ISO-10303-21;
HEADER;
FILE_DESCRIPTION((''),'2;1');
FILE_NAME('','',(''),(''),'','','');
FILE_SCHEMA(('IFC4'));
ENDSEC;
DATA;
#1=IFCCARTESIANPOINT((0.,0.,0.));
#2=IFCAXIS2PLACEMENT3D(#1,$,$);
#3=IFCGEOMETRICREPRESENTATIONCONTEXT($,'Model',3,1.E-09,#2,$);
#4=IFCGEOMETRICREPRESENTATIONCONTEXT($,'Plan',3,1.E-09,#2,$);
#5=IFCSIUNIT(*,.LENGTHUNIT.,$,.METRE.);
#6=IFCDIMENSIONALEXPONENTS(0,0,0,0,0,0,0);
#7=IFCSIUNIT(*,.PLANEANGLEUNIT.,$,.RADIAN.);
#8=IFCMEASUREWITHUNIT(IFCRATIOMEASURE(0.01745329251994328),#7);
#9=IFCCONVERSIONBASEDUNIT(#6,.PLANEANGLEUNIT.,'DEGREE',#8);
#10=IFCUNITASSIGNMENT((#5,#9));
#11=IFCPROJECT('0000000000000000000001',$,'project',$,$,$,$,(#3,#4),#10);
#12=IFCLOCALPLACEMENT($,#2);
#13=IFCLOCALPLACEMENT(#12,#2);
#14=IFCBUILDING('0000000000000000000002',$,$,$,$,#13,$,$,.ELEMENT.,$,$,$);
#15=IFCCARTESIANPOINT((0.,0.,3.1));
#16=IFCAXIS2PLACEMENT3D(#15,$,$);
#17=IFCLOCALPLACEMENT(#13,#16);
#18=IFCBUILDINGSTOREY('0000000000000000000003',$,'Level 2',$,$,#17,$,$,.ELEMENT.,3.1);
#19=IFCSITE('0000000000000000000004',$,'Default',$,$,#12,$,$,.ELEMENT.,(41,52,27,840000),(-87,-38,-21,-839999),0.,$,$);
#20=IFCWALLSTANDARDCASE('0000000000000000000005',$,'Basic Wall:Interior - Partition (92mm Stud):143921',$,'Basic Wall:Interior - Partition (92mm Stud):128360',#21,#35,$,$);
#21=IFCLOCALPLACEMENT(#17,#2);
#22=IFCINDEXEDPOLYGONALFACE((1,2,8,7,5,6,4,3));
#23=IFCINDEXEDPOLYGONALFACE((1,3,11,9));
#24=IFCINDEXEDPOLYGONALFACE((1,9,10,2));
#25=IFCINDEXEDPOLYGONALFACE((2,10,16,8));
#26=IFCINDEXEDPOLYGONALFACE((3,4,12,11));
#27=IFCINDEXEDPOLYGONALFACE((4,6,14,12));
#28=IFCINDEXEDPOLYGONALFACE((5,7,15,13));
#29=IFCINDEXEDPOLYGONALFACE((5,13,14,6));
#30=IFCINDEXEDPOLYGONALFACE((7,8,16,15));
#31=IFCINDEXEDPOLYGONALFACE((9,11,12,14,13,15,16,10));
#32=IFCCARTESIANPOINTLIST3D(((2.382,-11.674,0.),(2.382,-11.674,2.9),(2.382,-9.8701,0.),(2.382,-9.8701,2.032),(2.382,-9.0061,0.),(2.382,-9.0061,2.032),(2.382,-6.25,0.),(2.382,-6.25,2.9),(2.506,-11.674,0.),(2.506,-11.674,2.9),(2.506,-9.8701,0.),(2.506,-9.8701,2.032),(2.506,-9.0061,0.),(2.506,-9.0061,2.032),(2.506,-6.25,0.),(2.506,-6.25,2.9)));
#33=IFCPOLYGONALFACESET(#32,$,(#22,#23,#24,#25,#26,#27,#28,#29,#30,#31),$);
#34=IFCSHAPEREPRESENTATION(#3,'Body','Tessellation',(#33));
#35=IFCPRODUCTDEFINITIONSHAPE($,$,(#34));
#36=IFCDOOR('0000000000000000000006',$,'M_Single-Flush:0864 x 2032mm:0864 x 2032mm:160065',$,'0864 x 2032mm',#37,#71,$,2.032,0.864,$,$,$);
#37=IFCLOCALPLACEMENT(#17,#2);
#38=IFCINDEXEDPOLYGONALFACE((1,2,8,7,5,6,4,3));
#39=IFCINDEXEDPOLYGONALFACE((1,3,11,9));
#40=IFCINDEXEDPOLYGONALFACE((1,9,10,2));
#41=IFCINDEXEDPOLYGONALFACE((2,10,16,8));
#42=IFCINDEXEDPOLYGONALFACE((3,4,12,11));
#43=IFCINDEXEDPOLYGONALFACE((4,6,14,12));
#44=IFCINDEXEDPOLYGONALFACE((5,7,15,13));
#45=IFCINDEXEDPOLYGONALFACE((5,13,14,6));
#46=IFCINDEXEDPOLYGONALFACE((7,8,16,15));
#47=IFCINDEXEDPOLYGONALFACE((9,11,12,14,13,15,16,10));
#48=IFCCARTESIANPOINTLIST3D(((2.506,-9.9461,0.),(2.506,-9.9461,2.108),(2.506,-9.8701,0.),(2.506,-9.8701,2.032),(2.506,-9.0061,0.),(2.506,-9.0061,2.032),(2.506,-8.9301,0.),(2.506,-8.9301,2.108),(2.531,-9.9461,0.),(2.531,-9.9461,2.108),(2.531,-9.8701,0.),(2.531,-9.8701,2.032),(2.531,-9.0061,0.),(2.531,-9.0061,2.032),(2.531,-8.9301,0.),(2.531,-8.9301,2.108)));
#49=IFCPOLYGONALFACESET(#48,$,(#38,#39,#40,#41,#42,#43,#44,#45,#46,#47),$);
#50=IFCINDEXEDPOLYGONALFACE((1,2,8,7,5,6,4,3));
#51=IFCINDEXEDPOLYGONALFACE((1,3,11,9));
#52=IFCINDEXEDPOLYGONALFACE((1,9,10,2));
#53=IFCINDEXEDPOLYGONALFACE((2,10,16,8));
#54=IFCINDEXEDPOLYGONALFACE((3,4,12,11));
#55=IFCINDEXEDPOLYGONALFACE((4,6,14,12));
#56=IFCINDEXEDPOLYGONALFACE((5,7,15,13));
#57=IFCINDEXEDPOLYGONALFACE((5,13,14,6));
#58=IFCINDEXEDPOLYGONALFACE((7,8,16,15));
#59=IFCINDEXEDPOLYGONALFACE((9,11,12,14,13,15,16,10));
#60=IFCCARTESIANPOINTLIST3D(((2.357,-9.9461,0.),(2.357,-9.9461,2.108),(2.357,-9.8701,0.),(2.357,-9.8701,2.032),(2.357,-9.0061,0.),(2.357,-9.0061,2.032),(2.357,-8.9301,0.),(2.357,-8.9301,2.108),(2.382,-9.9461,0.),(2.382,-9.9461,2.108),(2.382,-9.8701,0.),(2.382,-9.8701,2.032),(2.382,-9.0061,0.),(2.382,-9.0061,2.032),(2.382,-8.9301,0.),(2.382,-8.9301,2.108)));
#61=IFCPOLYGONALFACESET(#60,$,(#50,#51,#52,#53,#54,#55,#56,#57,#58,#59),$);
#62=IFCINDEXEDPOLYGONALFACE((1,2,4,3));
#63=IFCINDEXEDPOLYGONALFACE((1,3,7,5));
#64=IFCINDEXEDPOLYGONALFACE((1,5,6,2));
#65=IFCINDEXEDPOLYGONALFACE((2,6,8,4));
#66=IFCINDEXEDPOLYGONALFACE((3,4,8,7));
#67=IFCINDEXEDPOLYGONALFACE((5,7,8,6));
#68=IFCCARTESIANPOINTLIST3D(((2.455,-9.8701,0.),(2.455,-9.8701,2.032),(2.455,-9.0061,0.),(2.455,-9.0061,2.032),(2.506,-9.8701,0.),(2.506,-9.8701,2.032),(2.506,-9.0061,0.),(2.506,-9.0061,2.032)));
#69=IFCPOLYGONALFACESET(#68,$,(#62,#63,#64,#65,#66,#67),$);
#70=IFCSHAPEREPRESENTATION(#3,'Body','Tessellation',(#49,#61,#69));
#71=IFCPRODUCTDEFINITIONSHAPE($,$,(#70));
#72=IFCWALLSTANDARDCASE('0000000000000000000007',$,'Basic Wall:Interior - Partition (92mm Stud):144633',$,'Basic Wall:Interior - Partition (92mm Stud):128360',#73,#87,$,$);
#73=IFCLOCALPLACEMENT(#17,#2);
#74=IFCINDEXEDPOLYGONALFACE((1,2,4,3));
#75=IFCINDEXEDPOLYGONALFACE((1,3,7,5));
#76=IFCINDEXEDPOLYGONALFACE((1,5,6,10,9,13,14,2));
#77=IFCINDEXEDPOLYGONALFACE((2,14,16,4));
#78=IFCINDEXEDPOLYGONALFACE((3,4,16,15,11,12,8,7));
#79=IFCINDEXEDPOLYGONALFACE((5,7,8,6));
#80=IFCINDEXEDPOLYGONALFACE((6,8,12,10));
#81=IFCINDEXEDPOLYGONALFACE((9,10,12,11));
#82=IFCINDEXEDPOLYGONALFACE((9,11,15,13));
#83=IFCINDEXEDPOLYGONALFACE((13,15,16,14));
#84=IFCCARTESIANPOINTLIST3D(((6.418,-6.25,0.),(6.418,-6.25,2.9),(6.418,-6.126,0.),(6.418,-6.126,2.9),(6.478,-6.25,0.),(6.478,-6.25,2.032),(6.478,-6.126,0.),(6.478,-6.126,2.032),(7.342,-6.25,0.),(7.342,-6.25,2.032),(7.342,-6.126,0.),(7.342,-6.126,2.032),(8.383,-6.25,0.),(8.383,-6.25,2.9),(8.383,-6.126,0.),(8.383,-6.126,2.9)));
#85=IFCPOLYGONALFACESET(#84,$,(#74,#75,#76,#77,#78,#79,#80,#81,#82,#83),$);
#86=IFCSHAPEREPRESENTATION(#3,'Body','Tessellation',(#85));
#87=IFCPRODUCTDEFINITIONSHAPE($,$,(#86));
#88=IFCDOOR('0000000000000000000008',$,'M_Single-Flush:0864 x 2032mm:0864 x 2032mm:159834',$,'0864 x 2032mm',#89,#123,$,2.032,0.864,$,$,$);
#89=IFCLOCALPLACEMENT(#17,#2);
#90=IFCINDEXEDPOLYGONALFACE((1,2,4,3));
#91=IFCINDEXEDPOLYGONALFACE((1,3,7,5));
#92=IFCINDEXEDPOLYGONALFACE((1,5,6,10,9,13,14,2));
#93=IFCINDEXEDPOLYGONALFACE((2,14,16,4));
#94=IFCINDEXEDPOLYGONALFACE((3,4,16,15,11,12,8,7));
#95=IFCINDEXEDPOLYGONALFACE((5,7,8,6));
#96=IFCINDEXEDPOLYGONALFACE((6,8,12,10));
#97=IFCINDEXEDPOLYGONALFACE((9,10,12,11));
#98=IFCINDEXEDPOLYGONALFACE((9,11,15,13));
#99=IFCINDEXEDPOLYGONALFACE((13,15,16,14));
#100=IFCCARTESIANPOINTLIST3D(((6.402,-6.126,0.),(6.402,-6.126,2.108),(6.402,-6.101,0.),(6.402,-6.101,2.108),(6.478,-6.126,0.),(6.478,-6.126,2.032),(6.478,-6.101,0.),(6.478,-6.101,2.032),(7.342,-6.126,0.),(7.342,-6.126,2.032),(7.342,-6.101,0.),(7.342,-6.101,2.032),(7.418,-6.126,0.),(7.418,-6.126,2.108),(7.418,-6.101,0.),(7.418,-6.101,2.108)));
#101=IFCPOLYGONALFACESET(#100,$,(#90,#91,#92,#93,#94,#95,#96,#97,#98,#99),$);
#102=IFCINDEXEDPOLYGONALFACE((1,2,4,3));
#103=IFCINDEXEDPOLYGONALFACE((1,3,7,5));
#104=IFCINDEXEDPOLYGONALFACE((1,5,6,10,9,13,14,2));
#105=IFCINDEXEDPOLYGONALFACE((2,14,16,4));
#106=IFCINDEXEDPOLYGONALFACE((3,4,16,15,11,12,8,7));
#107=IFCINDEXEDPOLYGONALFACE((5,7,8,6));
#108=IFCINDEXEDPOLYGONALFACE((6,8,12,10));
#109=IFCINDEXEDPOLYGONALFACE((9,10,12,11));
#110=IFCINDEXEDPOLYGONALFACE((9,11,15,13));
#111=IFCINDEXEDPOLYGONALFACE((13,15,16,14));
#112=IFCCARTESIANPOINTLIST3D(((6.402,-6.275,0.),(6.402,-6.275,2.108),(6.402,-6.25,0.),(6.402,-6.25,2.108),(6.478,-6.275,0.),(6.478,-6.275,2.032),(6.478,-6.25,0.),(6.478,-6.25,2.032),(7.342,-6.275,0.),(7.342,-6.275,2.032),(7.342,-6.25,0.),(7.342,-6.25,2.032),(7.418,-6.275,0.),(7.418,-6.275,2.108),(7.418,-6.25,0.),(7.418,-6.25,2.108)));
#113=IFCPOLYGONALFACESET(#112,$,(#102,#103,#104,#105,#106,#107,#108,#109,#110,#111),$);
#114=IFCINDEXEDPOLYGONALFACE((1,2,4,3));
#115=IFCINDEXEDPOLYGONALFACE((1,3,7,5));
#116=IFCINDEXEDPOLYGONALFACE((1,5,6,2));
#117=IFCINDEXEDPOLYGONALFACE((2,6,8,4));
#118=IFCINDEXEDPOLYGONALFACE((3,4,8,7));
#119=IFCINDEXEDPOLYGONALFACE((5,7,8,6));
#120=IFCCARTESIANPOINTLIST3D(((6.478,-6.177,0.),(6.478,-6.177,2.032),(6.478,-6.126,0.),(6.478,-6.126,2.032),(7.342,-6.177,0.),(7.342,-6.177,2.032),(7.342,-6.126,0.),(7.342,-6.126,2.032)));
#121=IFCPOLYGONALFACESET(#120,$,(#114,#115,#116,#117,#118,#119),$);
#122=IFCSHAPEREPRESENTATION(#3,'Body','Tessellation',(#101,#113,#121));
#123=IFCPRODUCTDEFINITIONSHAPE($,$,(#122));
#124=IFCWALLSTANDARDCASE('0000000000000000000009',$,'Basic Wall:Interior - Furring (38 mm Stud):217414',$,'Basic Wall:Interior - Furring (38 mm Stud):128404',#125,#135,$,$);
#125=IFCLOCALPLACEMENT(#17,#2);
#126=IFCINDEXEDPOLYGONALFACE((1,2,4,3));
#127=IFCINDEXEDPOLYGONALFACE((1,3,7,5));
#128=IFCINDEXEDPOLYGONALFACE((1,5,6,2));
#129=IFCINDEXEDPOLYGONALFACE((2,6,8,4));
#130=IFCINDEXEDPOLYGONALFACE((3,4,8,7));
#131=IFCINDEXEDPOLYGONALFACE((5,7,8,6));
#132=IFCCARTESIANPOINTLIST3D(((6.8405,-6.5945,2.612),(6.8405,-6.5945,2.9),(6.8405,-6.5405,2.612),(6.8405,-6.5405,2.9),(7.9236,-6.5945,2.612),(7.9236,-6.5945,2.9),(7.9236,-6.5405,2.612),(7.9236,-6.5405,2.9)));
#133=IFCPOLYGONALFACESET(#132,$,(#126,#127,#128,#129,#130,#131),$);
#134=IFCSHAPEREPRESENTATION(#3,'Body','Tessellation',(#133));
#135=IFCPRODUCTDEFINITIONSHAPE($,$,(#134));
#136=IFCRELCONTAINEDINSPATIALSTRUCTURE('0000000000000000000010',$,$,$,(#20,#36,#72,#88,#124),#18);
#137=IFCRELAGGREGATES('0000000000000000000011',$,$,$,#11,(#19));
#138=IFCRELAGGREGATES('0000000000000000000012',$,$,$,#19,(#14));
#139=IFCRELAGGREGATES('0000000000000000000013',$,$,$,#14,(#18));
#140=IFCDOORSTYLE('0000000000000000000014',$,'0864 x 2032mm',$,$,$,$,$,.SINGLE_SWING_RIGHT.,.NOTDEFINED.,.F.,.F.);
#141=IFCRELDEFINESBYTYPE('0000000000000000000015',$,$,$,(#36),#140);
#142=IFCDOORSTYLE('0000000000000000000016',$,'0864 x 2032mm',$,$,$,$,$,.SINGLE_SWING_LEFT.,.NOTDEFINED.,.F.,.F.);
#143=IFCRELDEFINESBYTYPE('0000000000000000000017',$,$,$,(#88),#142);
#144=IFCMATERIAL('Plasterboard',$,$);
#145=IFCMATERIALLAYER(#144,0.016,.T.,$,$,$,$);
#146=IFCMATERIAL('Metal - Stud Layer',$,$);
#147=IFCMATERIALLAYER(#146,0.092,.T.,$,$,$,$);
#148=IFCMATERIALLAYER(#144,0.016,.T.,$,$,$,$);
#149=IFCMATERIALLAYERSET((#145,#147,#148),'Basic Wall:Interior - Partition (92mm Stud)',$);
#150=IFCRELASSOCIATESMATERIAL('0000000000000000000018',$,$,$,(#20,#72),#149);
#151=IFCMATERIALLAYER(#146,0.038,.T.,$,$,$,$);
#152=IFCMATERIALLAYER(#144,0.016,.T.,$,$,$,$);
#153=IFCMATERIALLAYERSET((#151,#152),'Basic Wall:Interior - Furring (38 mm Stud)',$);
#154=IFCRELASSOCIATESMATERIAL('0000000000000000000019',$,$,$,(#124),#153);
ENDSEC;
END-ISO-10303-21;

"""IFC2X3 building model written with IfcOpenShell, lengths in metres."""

from ifc_helpers import new_model, entity, si_unit, converted_unit, frame, frame_2d, origin, origin_2d_with_axis, place, context, project, spatial, polyline, rectangle, outline, extrude, source, transform, mapped, material, layer, layer_set, layer_usage, type_object, type_shapes, element, fill, save


model = new_model("IFC2X3")

# Units and contexts
model_context = context("Model", 3, precision=1e-09, world=origin())
plan_context = context("Plan", 3, precision=1e-09, world=origin())
ifc_project = project(units=[si_unit("LENGTHUNIT", "METRE"), converted_unit("PLANEANGLEUNIT", "DEGREE", entity("IfcRatioMeasure", 0.01745329251994328), si_unit("PLANEANGLEUNIT", "RADIAN"), dimensions=[0, 0, 0, 0, 0, 0, 0])], contexts=[model_context, plan_context])

# Site, building, storey
site_placement = place(None, origin())
site = spatial("IfcSite", under=ifc_project, at=site_placement, Name="Default", CompositionType="ELEMENT", RefLatitude=(41, 52, 27, 840000), RefLongitude=(-87, -38, -21, -839999), RefElevation=0.0)
building_placement = place(site_placement, origin())
building = spatial("IfcBuilding", under=site, at=building_placement, CompositionType="ELEMENT")
storey_placement = place(building_placement, frame((0.0, 0.0, 3.1)))
storey = spatial("IfcBuildingStorey", under=building, at=storey_placement, Name="Level 2", CompositionType="ELEMENT", Elevation=3.1)

# Shared definitions
ifc_material_1 = material(Name="Metal - Stud Layer")
ifc_layer_1 = layer(ifc_material_1, 0.038, ventilated=True)
ifc_material_2 = material(Name="Plasterboard")
ifc_layer_2 = layer(ifc_material_2, 0.016, ventilated=True)
ifc_layer_set_1 = layer_set([ifc_layer_1, ifc_layer_2], Name="Basic Wall:Interior - Furring (38 mm Stud)")
ifc_layer_usage_1 = layer_usage(ifc_layer_set_1, "AXIS2", "NEGATIVE", 0.027)

# Walls, openings, doors
ifc_layer_3 = layer(ifc_material_2, 0.016, ventilated=True)
ifc_layer_4 = layer(ifc_material_1, 0.092, ventilated=True)
ifc_layer_5 = layer(ifc_material_2, 0.016, ventilated=True)
ifc_layer_set_2 = layer_set([ifc_layer_3, ifc_layer_4, ifc_layer_5], Name="Basic Wall:Interior - Partition (92mm Stud)")
ifc_layer_usage_2 = layer_usage(ifc_layer_set_2, "AXIS2", "NEGATIVE", 0.062)
wall_1_placement = place(storey_placement, frame((2.444, -6.25, 0.0), z_axis=(0.0, 0.0, 1.0), x_axis=(0.0, -1.0, 0.0)))
wall_1 = element("IfcWallStandardCase", 1, at=wall_1_placement, inside=storey, material=ifc_layer_usage_2, Name="Basic Wall:Interior - Partition (92mm Stud):143921", ObjectType="Basic Wall:Interior - Partition (92mm Stud):128360", context=model_context, shape_type="SweptSolid", body=[
    extrude(rectangle(XDim=5.424, YDim=0.124, at=frame_2d((2.712, 0.0), x_axis=(-1.0, 0.0))), origin(), (0.0, 0.0, 1.0), 2.9),
])
opening_1_placement = place(wall_1_placement, frame((2.7561, -0.062, 0.0)))
opening_1 = element("IfcOpeningElement", 2, at=opening_1_placement, cuts=wall_1, ObjectType="Opening", context=model_context, shape_type="SweptSolid", body=[
    extrude(rectangle(XDim=0.864, YDim=2.032, at=frame_2d((1.016, 0.432), x_axis=(0.0, 1.0))), frame((0.0, 0.0, 0.0), z_axis=(0.0, 1.0, 0.0), x_axis=(0.0, 0.0, 1.0)), (0.0, 0.0, 1.0), 0.124),
])
door_style_1 = type_object("IfcDoorStyle", Name="0864 x 2032mm", ConstructionType="NOTDEFINED", OperationType="SINGLE_SWING_RIGHT", ParameterTakesPrecedence=False, Sizeable=False)
shared_shape_1 = source(origin(), model_context, "Body", "SweptSolid", [
    extrude(outline(polyline([(-0.508, -1.073), (0.508, -1.073), (0.508, 1.035), (0.432, 1.035), (0.432, -0.997), (-0.432, -0.997), (-0.432, 1.035), (-0.508, 1.035), (-0.508, -1.073)])), frame((0.432, 0.124, 1.035), z_axis=(0.0, 1.0, 0.0), x_axis=(1.0, 0.0, 0.0)), (0.0, 0.0, 1.0), 0.025),
    extrude(outline(polyline([(-1.073, -0.508), (1.035, -0.508), (1.035, -0.432), (-0.997, -0.432), (-0.997, 0.432), (1.035, 0.432), (1.035, 0.508), (-1.073, 0.508), (-1.073, -0.508)])), frame((0.432, -0.025, 1.035), z_axis=(0.0, 1.0, 0.0), x_axis=(0.0, 0.0, -1.0)), (0.0, 0.0, 1.0), 0.025),
    extrude(rectangle(XDim=0.051, YDim=0.864, at=origin_2d_with_axis()), frame((0.432, 0.0985, 0.0), z_axis=(0.0, 0.0, 1.0), x_axis=(0.0, 1.0, 0.0)), (0.0, 0.0, 1.0), 2.032),
])
type_shapes(door_style_1, [shared_shape_1])
door_1_placement = place(opening_1_placement, origin())
door_1 = element("IfcDoor", 3, at=door_1_placement, inside=storey, type_object=door_style_1, Name="M_Single-Flush:0864 x 2032mm:0864 x 2032mm:160065", ObjectType="0864 x 2032mm", OverallHeight=2.032, OverallWidth=0.864, context=model_context, shape_type="MappedRepresentation", body=[
    mapped(shared_shape_1, transform((0.0, 0.0, 0.0), scale=1.0)),
])
fill(opening_1, door_1)
wall_2_placement = place(storey_placement, frame((6.418, -6.188, 0.0)))
wall_2 = element("IfcWallStandardCase", 4, at=wall_2_placement, inside=storey, material=ifc_layer_usage_2, Name="Basic Wall:Interior - Partition (92mm Stud):144633", ObjectType="Basic Wall:Interior - Partition (92mm Stud):128360", context=model_context, shape_type="SweptSolid", body=[
    extrude(rectangle(XDim=1.965, YDim=0.124, at=frame_2d((0.9825, 0.0), x_axis=(-1.0, 0.0))), origin(), (0.0, 0.0, 1.0), 2.9),
])
opening_2_placement = place(wall_2_placement, frame((0.06, -0.062, 0.0)))
opening_2 = element("IfcOpeningElement", 5, at=opening_2_placement, cuts=wall_2, ObjectType="Opening", context=model_context, shape_type="SweptSolid", body=[
    extrude(rectangle(XDim=0.864, YDim=2.032, at=frame_2d((1.016, 0.432), x_axis=(0.0, -1.0))), frame((0.0, 0.0, 0.0), z_axis=(0.0, 1.0, 0.0), x_axis=(0.0, 0.0, 1.0)), (0.0, 0.0, 1.0), 0.124),
])
door_style_2 = type_object("IfcDoorStyle", Name="0864 x 2032mm", ConstructionType="NOTDEFINED", OperationType="SINGLE_SWING_LEFT", ParameterTakesPrecedence=False, Sizeable=False)
shared_shape_2 = source(origin(), model_context, "Body", "SweptSolid", [
    extrude(outline(polyline([(-0.508, -1.073), (0.508, -1.073), (0.508, 1.035), (0.432, 1.035), (0.432, -0.997), (-0.432, -0.997), (-0.432, 1.035), (-0.508, 1.035), (-0.508, -1.073)])), frame((0.432, 0.149, 1.035), z_axis=(0.0, -1.0, 0.0), x_axis=(-1.0, 0.0, 0.0)), (0.0, 0.0, 1.0), 0.025),
    extrude(outline(polyline([(-1.073, -0.508), (1.035, -0.508), (1.035, -0.432), (-0.997, -0.432), (-0.997, 0.432), (1.035, 0.432), (1.035, 0.508), (-1.073, 0.508), (-1.073, -0.508)])), frame((0.432, 0.0, 1.035), z_axis=(0.0, -1.0, 0.0), x_axis=(0.0, 0.0, -1.0)), (0.0, 0.0, 1.0), 0.025),
    extrude(rectangle(XDim=0.864, YDim=0.051, at=origin_2d_with_axis()), frame((0.432, 0.0985, 0.0)), (0.0, 0.0, 1.0), 2.032),
])
type_shapes(door_style_2, [shared_shape_2])
door_2_placement = place(opening_2_placement, origin())
door_2 = element("IfcDoor", 6, at=door_2_placement, inside=storey, type_object=door_style_2, Name="M_Single-Flush:0864 x 2032mm:0864 x 2032mm:159834", ObjectType="0864 x 2032mm", OverallHeight=2.032, OverallWidth=0.864, context=model_context, shape_type="MappedRepresentation", body=[
    mapped(shared_shape_2, transform((0.0, 0.0, 0.0), scale=1.0)),
])
fill(opening_2, door_2)

# Wall
wall_3_placement = place(storey_placement, frame((6.8405, -6.5675, 2.612)))
element("IfcWallStandardCase", 7, at=wall_3_placement, inside=storey, material=ifc_layer_usage_1, Name="Basic Wall:Interior - Furring (38 mm Stud):217414", ObjectType="Basic Wall:Interior - Furring (38 mm Stud):128404", context=model_context, shape_type="SweptSolid", body=[
    extrude(rectangle(XDim=1.0831, YDim=0.054, at=frame_2d((0.5416, 0.0), x_axis=(-1.0, 0.0))), origin(), (0.0, 0.0, 1.0), 0.288),
])

save(model, "model.ifc")
